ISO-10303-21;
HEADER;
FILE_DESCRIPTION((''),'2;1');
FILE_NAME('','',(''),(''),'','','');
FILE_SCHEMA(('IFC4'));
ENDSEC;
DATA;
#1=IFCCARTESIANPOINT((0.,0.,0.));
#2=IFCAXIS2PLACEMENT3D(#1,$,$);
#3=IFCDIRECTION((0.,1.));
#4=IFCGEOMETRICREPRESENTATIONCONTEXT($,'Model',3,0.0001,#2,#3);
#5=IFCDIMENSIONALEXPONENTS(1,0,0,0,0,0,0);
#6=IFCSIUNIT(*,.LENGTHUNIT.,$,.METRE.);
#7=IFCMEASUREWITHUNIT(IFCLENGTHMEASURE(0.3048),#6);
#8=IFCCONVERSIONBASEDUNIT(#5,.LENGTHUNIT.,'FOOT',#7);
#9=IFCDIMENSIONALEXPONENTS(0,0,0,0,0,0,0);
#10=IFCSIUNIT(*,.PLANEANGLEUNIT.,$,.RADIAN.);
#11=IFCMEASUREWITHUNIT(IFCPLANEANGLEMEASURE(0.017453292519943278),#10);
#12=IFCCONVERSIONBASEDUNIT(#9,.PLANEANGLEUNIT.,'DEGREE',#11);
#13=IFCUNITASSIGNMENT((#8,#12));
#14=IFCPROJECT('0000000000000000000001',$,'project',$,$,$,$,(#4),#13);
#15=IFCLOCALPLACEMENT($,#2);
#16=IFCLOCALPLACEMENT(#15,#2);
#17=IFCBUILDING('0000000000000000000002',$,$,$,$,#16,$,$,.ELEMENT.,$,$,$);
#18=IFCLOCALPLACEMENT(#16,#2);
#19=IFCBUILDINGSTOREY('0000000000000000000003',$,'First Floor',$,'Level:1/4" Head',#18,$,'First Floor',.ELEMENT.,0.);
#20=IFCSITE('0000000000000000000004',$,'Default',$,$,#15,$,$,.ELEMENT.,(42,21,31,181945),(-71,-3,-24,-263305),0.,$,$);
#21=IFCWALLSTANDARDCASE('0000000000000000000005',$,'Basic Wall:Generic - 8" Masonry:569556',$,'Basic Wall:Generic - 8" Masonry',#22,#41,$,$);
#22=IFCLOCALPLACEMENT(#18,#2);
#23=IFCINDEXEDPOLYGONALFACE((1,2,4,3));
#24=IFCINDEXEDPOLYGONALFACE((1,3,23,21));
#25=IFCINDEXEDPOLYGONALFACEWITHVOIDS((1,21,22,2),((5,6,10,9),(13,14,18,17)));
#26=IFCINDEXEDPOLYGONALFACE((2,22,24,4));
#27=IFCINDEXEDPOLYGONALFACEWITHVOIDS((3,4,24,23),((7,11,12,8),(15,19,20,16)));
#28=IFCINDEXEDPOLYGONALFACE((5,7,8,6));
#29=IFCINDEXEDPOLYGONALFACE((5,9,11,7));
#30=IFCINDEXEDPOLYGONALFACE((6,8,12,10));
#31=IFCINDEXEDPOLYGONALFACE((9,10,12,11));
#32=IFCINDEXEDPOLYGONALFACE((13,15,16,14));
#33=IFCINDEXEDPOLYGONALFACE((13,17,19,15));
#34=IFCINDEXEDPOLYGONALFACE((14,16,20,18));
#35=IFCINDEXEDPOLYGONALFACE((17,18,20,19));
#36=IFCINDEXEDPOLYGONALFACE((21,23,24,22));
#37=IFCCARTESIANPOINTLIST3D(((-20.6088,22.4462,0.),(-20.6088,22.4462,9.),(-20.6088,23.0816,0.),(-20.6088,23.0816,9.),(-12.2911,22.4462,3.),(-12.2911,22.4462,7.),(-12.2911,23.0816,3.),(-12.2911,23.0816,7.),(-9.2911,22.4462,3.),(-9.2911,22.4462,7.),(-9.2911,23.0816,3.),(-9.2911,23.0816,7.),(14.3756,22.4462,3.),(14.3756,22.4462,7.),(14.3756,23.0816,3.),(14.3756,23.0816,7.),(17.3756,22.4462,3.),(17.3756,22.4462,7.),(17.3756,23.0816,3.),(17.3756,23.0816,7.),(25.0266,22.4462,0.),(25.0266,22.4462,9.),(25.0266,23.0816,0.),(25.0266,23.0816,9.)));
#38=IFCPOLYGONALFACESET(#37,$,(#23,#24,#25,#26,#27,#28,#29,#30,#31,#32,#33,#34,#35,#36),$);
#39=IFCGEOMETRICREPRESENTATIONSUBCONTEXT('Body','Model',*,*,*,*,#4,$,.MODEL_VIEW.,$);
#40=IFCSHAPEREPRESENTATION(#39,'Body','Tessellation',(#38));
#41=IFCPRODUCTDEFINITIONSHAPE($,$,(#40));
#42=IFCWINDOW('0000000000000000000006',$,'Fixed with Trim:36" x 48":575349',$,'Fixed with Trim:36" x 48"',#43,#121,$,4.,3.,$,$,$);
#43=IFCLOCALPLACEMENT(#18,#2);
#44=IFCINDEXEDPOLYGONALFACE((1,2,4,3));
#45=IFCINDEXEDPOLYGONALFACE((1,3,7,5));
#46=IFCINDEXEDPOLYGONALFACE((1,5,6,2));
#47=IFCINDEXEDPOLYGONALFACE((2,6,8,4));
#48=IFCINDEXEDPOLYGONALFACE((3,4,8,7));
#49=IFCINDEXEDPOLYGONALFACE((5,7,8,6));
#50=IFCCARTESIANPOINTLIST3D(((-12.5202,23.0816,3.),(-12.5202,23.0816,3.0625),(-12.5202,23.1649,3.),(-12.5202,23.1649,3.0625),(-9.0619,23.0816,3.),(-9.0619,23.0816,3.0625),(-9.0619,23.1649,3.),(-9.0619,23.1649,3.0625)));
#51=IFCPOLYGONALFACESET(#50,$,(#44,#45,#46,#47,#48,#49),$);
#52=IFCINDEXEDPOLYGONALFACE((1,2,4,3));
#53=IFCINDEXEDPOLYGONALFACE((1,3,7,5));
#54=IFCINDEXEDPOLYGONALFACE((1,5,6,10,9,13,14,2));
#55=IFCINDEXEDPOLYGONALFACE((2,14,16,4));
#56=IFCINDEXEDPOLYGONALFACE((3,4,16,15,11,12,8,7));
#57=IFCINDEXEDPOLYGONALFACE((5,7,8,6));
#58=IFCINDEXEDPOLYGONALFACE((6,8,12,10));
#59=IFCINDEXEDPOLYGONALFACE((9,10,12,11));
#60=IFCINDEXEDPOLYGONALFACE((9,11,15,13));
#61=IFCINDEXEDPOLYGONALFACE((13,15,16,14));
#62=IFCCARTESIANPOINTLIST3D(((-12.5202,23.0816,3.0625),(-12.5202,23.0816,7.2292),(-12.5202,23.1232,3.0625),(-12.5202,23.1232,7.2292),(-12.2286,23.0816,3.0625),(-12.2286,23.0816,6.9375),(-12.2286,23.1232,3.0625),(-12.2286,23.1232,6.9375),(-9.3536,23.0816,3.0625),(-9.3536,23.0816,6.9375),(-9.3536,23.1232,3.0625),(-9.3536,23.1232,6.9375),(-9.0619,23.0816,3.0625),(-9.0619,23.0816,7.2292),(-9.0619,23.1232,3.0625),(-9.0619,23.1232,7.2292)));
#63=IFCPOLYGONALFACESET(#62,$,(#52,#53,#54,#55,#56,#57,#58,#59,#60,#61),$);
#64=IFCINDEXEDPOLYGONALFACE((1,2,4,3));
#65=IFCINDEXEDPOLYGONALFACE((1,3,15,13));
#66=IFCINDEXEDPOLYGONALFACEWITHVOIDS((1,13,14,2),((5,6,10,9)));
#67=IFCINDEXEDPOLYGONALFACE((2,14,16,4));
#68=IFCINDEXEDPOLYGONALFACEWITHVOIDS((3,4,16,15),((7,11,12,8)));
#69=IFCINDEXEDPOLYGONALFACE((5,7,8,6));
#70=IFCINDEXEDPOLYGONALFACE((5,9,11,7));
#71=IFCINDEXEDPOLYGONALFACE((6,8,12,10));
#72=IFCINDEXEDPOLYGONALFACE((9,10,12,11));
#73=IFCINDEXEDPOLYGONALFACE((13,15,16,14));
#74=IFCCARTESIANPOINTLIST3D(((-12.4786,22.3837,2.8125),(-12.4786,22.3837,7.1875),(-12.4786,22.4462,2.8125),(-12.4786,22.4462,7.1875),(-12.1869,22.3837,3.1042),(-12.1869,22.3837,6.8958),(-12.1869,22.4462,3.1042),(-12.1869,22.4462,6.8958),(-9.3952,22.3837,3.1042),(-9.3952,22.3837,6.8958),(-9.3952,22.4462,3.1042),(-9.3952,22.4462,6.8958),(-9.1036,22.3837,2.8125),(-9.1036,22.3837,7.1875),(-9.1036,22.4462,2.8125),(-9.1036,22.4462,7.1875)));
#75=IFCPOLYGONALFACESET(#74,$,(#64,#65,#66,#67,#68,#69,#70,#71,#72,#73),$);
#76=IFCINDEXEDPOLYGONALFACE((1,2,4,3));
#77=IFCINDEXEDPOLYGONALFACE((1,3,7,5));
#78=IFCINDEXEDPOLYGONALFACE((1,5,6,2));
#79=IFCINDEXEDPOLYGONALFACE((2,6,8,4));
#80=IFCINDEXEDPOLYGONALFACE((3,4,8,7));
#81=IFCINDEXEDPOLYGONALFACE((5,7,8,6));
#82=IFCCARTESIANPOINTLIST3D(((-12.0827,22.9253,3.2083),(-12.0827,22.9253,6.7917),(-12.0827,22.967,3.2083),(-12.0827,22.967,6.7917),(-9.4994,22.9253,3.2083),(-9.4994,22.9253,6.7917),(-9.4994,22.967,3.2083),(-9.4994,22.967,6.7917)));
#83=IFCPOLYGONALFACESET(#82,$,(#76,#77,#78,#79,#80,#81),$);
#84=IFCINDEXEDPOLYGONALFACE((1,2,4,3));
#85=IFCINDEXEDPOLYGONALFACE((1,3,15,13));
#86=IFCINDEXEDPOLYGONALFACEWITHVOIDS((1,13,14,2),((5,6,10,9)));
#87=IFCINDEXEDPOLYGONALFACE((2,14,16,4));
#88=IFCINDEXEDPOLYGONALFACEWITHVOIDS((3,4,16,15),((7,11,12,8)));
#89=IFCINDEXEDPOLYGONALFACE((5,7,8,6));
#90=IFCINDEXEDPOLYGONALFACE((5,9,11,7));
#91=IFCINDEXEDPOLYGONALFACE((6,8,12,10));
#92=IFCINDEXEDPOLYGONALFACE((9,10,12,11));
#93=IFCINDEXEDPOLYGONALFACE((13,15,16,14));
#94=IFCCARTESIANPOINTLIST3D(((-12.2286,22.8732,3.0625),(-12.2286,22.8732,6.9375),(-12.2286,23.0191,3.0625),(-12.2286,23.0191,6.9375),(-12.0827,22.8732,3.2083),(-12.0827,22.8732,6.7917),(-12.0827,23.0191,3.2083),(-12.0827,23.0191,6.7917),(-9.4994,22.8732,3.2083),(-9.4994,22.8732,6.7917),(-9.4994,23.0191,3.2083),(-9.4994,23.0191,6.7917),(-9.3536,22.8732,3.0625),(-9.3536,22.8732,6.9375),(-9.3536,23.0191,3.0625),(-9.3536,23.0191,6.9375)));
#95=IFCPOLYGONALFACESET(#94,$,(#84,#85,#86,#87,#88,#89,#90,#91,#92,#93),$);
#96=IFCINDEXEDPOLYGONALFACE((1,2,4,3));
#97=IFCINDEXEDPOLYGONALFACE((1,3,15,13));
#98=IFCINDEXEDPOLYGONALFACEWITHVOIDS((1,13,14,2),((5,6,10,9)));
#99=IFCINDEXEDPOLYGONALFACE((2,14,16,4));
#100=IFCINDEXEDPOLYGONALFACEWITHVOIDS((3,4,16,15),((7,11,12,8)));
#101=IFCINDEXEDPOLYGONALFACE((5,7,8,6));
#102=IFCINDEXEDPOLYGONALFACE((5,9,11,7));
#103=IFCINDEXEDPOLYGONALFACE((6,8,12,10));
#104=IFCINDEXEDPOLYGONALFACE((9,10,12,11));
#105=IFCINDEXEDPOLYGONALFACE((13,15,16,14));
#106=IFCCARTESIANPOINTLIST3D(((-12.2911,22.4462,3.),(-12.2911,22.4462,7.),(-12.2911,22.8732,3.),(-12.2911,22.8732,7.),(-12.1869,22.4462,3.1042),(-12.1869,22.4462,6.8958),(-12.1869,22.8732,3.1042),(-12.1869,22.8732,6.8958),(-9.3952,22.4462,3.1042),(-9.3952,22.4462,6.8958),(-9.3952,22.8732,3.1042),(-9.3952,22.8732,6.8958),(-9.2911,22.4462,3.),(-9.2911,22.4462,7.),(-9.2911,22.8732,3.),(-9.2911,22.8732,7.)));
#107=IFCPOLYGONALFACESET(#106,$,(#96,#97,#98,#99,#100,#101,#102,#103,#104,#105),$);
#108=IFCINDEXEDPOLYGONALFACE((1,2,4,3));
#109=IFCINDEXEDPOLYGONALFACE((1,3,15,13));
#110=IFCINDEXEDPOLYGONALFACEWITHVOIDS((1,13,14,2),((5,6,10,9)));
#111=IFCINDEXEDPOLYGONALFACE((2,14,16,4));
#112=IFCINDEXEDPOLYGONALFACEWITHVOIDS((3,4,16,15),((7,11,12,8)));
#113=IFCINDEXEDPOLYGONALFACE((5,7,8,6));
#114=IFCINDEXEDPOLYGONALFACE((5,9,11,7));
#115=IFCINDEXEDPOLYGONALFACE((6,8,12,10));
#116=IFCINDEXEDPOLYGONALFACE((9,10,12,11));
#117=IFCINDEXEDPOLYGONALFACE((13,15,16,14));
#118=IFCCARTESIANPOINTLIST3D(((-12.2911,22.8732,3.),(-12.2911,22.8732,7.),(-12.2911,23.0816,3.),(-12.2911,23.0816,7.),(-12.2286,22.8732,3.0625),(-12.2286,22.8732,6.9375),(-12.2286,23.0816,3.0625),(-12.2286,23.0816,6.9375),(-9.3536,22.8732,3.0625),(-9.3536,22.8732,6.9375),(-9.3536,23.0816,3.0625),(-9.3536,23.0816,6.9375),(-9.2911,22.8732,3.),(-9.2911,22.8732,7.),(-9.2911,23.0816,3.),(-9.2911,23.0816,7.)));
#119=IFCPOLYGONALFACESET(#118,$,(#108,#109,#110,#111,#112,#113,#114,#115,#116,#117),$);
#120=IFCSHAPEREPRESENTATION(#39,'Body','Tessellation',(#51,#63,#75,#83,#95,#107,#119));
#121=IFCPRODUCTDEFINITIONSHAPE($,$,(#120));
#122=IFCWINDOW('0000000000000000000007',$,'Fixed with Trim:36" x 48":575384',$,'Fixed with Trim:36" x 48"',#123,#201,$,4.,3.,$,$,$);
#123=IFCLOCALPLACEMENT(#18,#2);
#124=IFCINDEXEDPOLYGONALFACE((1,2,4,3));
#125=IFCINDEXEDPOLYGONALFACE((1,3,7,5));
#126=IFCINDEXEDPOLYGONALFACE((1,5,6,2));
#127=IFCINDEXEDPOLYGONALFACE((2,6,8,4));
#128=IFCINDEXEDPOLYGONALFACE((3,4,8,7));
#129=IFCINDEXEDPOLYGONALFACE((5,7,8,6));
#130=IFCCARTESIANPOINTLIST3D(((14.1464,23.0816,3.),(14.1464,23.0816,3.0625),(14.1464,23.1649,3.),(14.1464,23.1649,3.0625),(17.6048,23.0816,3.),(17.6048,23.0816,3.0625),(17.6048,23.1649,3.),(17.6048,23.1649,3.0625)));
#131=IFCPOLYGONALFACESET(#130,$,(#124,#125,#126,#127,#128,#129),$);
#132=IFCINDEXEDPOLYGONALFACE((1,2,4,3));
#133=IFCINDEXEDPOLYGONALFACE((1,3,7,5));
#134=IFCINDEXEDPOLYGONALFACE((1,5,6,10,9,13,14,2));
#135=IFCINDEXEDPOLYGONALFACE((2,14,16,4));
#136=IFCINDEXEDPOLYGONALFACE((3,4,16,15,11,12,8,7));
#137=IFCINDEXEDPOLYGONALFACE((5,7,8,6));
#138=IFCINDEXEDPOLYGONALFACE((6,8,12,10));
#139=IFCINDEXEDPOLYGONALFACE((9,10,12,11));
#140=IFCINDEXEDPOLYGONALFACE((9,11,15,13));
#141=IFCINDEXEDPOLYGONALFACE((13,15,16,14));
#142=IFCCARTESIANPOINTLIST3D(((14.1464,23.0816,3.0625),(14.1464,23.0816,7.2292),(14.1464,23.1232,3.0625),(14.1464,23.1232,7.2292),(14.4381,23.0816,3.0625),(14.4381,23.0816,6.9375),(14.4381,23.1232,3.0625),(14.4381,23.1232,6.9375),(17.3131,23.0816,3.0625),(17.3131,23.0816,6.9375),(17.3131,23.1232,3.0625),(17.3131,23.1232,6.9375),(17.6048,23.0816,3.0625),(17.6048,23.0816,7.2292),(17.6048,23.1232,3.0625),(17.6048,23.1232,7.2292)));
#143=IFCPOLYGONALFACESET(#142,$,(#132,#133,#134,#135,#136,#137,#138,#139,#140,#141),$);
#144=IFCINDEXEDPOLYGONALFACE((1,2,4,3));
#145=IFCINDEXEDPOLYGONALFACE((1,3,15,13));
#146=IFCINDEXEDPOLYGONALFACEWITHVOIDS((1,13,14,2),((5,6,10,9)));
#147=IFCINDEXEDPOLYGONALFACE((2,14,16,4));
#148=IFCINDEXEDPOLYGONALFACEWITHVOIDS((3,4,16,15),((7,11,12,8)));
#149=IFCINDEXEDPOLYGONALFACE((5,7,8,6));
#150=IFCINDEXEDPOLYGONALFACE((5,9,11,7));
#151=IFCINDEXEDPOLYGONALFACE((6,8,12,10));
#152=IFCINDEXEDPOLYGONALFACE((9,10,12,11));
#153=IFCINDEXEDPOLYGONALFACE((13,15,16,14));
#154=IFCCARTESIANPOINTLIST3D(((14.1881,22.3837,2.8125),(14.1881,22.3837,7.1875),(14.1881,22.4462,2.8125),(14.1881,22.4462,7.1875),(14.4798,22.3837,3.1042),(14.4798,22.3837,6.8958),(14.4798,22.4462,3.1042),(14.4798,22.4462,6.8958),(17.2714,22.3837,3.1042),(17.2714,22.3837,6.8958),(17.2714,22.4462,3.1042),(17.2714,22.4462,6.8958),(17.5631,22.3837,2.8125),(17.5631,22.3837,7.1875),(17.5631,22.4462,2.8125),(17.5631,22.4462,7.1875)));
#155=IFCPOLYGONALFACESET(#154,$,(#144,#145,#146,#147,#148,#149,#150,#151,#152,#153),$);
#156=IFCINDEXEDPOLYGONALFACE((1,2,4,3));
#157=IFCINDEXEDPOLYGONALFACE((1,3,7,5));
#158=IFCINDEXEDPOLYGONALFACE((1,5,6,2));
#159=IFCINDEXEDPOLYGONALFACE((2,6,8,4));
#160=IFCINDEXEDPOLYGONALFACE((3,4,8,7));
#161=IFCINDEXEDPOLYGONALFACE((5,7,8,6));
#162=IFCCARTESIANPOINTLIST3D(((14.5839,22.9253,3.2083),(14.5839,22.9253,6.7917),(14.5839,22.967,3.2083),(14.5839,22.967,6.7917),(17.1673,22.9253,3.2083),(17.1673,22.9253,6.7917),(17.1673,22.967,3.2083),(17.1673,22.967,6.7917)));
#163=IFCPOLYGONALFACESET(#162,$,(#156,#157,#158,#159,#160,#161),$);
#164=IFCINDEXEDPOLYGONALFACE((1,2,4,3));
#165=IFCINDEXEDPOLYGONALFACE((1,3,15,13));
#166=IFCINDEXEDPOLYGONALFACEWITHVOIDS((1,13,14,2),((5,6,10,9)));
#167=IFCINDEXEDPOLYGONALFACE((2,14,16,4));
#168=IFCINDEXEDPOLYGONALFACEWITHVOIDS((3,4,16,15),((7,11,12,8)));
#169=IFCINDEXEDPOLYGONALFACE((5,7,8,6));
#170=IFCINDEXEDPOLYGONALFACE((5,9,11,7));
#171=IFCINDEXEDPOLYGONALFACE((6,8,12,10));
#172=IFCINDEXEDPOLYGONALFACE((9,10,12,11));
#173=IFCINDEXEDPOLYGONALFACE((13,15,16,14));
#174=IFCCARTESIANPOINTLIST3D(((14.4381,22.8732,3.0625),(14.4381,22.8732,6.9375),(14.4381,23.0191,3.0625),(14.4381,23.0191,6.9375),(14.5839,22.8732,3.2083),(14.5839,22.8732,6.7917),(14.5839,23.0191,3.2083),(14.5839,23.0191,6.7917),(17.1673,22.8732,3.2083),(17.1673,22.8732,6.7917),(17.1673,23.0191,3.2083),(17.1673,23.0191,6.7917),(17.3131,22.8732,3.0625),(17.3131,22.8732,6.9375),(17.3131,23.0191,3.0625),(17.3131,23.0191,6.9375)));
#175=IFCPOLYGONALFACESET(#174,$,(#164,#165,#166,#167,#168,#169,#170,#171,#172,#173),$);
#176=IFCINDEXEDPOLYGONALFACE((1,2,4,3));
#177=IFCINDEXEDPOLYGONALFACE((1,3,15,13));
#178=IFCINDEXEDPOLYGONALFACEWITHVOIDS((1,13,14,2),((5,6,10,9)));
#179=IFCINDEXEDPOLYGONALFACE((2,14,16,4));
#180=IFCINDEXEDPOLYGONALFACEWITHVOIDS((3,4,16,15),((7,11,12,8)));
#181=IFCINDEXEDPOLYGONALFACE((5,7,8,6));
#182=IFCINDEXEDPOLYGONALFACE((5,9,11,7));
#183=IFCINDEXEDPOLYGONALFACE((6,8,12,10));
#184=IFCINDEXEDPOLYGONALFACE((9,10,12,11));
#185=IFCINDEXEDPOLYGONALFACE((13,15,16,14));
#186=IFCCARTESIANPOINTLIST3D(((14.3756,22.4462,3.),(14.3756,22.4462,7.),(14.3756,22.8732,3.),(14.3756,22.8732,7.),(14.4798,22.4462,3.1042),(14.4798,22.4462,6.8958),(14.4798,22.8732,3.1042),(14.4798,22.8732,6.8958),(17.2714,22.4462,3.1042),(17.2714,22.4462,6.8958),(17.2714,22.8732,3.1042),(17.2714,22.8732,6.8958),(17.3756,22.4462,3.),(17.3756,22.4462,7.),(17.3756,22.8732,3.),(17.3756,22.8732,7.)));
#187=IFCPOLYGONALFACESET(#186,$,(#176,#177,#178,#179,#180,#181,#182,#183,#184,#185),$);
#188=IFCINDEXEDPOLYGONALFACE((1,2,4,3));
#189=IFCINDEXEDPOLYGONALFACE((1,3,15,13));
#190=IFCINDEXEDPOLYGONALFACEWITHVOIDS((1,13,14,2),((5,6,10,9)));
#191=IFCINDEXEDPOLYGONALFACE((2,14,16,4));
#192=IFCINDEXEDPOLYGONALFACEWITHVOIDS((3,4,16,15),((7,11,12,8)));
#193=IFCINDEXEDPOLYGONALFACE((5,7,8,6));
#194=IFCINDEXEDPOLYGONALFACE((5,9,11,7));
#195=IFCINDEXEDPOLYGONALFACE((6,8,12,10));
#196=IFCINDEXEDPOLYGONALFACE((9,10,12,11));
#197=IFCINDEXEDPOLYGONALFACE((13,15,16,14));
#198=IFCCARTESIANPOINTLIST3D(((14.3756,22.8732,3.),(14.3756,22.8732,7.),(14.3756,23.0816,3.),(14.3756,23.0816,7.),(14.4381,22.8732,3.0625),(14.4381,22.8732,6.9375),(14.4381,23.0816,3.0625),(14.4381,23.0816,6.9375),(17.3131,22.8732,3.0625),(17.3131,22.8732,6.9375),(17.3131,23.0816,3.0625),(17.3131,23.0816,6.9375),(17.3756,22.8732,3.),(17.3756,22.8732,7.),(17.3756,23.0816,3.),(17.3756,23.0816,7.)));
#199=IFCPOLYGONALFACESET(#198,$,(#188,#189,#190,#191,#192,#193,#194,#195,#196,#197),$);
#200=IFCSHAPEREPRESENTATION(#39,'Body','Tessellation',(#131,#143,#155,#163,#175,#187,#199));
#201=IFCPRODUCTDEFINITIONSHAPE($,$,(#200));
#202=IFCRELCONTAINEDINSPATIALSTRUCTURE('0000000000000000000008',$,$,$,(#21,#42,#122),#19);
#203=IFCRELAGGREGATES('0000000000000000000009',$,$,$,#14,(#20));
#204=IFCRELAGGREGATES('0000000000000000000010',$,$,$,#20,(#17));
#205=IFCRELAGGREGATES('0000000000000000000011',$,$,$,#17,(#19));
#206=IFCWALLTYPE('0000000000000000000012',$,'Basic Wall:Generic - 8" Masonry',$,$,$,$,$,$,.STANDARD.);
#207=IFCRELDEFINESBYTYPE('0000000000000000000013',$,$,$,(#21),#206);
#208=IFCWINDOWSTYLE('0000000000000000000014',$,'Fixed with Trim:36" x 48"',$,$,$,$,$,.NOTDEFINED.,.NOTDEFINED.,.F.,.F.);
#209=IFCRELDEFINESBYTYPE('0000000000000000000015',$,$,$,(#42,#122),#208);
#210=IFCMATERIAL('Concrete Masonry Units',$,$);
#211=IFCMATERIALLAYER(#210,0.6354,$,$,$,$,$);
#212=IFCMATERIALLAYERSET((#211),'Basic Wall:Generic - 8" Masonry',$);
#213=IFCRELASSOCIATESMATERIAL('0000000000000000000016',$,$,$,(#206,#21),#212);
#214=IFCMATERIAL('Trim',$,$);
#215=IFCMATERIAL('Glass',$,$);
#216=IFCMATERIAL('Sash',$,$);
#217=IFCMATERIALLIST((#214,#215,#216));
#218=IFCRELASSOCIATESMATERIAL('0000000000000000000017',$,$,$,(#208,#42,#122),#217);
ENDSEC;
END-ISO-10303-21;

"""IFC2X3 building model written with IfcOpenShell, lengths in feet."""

from ifc_helpers import new_model, entity, si_unit, converted_unit, direction, frame, frame_2d, origin, origin_2d_with_axis, place, context, subcontext, project, spatial, polyline, rectangle, outline, extrude, source, transform, mapped, material, material_list, layer, layer_set, layer_usage, type_object, type_shapes, element, fill, save


model = new_model("IFC2X3")

# Units and contexts
model_context = context("Model", 3, precision=0.0001, world=origin(), true_north=direction((0.0, 1.0)))
body_context = subcontext(model_context, "Body", "Model", "MODEL_VIEW")
ifc_project = project(units=[converted_unit("LENGTHUNIT", "FOOT", entity("IfcLengthMeasure", 0.3048), si_unit("LENGTHUNIT", "METRE"), dimensions=[1, 0, 0, 0, 0, 0, 0]), converted_unit("PLANEANGLEUNIT", "DEGREE", entity("IfcPlaneAngleMeasure", 0.017453292519943278), si_unit("PLANEANGLEUNIT", "RADIAN"), dimensions=[0, 0, 0, 0, 0, 0, 0])], contexts=[model_context])

# Site, building, storey
site_placement = place(None, origin())
site = spatial("IfcSite", under=ifc_project, at=site_placement, Name="Default", CompositionType="ELEMENT", RefLatitude=(42, 21, 31, 181945), RefLongitude=(-71, -3, -24, -263305), RefElevation=0.0)
building_placement = place(site_placement, origin())
building = spatial("IfcBuilding", under=site, at=building_placement, CompositionType="ELEMENT")
storey_placement = place(building_placement, origin())
storey = spatial("IfcBuildingStorey", under=building, at=storey_placement, Name="First Floor", ObjectType="Level:1/4\" Head", LongName="First Floor", CompositionType="ELEMENT", Elevation=0.0)

# Wall, openings, windows
ifc_material_1 = material(Name="Concrete Masonry Units")
ifc_layer_1 = layer(ifc_material_1, 0.6354)
ifc_layer_set_1 = layer_set([ifc_layer_1], Name="Basic Wall:Generic - 8\" Masonry")
ifc_layer_usage_1 = layer_usage(ifc_layer_set_1, "AXIS2", "NEGATIVE", 0.3177)
wall_type = type_object("IfcWallType", Name="Basic Wall:Generic - 8\" Masonry", PredefinedType="STANDARD", material=ifc_layer_set_1)
wall_1_placement = place(storey_placement, frame((-20.6088, 22.7639, 0.0)))
wall_1 = element("IfcWallStandardCase", 1, at=wall_1_placement, inside=storey, type_object=wall_type, material=ifc_layer_usage_1, Name="Basic Wall:Generic - 8\" Masonry:569556", ObjectType="Basic Wall:Generic - 8\" Masonry", context=body_context, shape_type="SweptSolid", body=[
    extrude(rectangle(XDim=45.6354, YDim=0.6354, at=frame_2d((22.8177, 0.0), x_axis=(-1.0, 0.0))), origin(), (0.0, 0.0, 1.0), 9.0),
])
opening_1_placement = place(wall_1_placement, frame((8.3177, -0.3177, 3.0)))
opening_1 = element("IfcOpeningElement", 2, at=opening_1_placement, cuts=wall_1, ObjectType="Opening", context=body_context, shape_type="SweptSolid", body=[
    extrude(rectangle(XDim=4.0, YDim=3.0, at=frame_2d((2.0, 1.5), x_axis=(-1.0, 0.0))), frame((0.0, 0.0, 0.0), z_axis=(0.0, 1.0, 0.0), x_axis=(0.0, 0.0, 1.0)), (0.0, 0.0, 1.0), 0.6354),
])
opening_2_placement = place(wall_1_placement, frame((34.9844, -0.3177, 3.0)))
opening_2 = element("IfcOpeningElement", 3, at=opening_2_placement, cuts=wall_1, ObjectType="Opening", context=body_context, shape_type="SweptSolid", body=[
    extrude(rectangle(XDim=4.0, YDim=3.0, at=frame_2d((2.0, 1.5), x_axis=(-1.0, 0.0))), frame((0.0, 0.0, 0.0), z_axis=(0.0, 1.0, 0.0), x_axis=(0.0, 0.0, 1.0)), (0.0, 0.0, 1.0), 0.6354),
])
ifc_material_2 = material(Name="Trim")
ifc_material_3 = material(Name="Glass")
ifc_material_4 = material(Name="Sash")
ifc_material_list_1 = material_list([ifc_material_2, ifc_material_3, ifc_material_4])
window_style = type_object("IfcWindowStyle", Name="Fixed with Trim:36\" x 48\"", ConstructionType="NOTDEFINED", OperationType="NOTDEFINED", ParameterTakesPrecedence=False, Sizeable=False, material=ifc_material_list_1)
shared_shape_1 = source(origin(), body_context, "Body", "SweptSolid", [
    extrude(rectangle(XDim=0.0833, YDim=3.4583, at=origin_2d_with_axis()), frame((1.5, 0.6771, 0.0), z_axis=(0.0, 0.0, 1.0), x_axis=(0.0, -1.0, 0.0)), (0.0, 0.0, 1.0), 0.0625),
    extrude(outline(polyline([(-1.8646, 1.4375), (2.0104, 1.4375), (2.0104, 1.7292), (-2.1562, 1.7292), (-2.1562, -1.7292), (2.0104, -1.7292), (2.0104, -1.4375), (-1.8646, -1.4375), (-1.8646, 1.4375)])), frame((1.5, 0.6354, 2.0729), z_axis=(0.0, 1.0, 0.0), x_axis=(0.0, 0.0, -1.0)), (0.0, 0.0, 1.0), 0.0417),
    extrude(outline(polyline([(-2.1875, -1.6875), (2.1875, -1.6875), (2.1875, 1.6875), (-2.1875, 1.6875), (-2.1875, -1.6875)]), holes=[polyline([(-1.8958, -1.3958), (-1.8958, 1.3958), (1.8958, 1.3958), (1.8958, -1.3958), (-1.8958, -1.3958)])]), frame((1.5, -0.0625, 2.0), z_axis=(0.0, 1.0, 0.0), x_axis=(0.0, 0.0, -1.0)), (0.0, 0.0, 1.0), 0.0625),
    extrude(rectangle(XDim=0.0417, YDim=2.5833, at=frame_2d((0.0, 0.0), x_axis=(1.0, 0.0))), frame((1.5, 0.5, 0.2083), z_axis=(0.0, 0.0, 1.0), x_axis=(0.0, 1.0, 0.0)), (0.0, 0.0, 1.0), 3.5833),
    extrude(outline(polyline([(-1.4375, -1.9375), (1.4375, -1.9375), (1.4375, 1.9375), (-1.4375, 1.9375), (-1.4375, -1.9375)]), holes=[polyline([(-1.2917, -1.7917), (-1.2917, 1.7917), (1.2917, 1.7917), (1.2917, -1.7917), (-1.2917, -1.7917)])]), frame((1.5, 0.4271, 2.0), z_axis=(0.0, 1.0, 0.0), x_axis=(1.0, 0.0, 0.0)), (0.0, 0.0, 1.0), 0.1458),
    extrude(outline(polyline([(-1.5, -2.0), (1.5, -2.0), (1.5, 2.0), (-1.5, 2.0), (-1.5, -2.0)]), holes=[polyline([(-1.3958, -1.8958), (-1.3958, 1.8958), (1.3958, 1.8958), (1.3958, -1.8958), (-1.3958, -1.8958)])]), frame((1.5, 0.0, 2.0), z_axis=(0.0, 1.0, 0.0), x_axis=(1.0, 0.0, 0.0)), (0.0, 0.0, 1.0), 0.4271),
    extrude(outline(polyline([(-2.0, -1.5), (2.0, -1.5), (2.0, 1.5), (-2.0, 1.5), (-2.0, -1.5)]), holes=[polyline([(-1.9375, -1.4375), (-1.9375, 1.4375), (1.9375, 1.4375), (1.9375, -1.4375), (-1.9375, -1.4375)])]), frame((1.5, 0.4271, 2.0), z_axis=(0.0, 1.0, 0.0), x_axis=(0.0, 0.0, -1.0)), (0.0, 0.0, 1.0), 0.2083),
])
type_shapes(window_style, [shared_shape_1])
window_1_placement = place(opening_1_placement, origin())
window_1 = element("IfcWindow", 4, at=window_1_placement, inside=storey, type_object=window_style, material=ifc_material_list_1, Name="Fixed with Trim:36\" x 48\":575349", ObjectType="Fixed with Trim:36\" x 48\"", OverallHeight=4.0, OverallWidth=3.0, context=body_context, shape_type="MappedRepresentation", body=[
    mapped(shared_shape_1, transform((0.0, 0.0, 0.0), scale=1.0)),
])
fill(opening_1, window_1)
window_2_placement = place(opening_2_placement, origin())
window_2 = element("IfcWindow", 5, at=window_2_placement, inside=storey, type_object=window_style, material=ifc_material_list_1, Name="Fixed with Trim:36\" x 48\":575384", ObjectType="Fixed with Trim:36\" x 48\"", OverallHeight=4.0, OverallWidth=3.0, context=body_context, shape_type="MappedRepresentation", body=[
    mapped(shared_shape_1, transform((0.0, 0.0, 0.0), scale=1.0)),
])
fill(opening_2, window_2)

save(model, "model.ifc")
